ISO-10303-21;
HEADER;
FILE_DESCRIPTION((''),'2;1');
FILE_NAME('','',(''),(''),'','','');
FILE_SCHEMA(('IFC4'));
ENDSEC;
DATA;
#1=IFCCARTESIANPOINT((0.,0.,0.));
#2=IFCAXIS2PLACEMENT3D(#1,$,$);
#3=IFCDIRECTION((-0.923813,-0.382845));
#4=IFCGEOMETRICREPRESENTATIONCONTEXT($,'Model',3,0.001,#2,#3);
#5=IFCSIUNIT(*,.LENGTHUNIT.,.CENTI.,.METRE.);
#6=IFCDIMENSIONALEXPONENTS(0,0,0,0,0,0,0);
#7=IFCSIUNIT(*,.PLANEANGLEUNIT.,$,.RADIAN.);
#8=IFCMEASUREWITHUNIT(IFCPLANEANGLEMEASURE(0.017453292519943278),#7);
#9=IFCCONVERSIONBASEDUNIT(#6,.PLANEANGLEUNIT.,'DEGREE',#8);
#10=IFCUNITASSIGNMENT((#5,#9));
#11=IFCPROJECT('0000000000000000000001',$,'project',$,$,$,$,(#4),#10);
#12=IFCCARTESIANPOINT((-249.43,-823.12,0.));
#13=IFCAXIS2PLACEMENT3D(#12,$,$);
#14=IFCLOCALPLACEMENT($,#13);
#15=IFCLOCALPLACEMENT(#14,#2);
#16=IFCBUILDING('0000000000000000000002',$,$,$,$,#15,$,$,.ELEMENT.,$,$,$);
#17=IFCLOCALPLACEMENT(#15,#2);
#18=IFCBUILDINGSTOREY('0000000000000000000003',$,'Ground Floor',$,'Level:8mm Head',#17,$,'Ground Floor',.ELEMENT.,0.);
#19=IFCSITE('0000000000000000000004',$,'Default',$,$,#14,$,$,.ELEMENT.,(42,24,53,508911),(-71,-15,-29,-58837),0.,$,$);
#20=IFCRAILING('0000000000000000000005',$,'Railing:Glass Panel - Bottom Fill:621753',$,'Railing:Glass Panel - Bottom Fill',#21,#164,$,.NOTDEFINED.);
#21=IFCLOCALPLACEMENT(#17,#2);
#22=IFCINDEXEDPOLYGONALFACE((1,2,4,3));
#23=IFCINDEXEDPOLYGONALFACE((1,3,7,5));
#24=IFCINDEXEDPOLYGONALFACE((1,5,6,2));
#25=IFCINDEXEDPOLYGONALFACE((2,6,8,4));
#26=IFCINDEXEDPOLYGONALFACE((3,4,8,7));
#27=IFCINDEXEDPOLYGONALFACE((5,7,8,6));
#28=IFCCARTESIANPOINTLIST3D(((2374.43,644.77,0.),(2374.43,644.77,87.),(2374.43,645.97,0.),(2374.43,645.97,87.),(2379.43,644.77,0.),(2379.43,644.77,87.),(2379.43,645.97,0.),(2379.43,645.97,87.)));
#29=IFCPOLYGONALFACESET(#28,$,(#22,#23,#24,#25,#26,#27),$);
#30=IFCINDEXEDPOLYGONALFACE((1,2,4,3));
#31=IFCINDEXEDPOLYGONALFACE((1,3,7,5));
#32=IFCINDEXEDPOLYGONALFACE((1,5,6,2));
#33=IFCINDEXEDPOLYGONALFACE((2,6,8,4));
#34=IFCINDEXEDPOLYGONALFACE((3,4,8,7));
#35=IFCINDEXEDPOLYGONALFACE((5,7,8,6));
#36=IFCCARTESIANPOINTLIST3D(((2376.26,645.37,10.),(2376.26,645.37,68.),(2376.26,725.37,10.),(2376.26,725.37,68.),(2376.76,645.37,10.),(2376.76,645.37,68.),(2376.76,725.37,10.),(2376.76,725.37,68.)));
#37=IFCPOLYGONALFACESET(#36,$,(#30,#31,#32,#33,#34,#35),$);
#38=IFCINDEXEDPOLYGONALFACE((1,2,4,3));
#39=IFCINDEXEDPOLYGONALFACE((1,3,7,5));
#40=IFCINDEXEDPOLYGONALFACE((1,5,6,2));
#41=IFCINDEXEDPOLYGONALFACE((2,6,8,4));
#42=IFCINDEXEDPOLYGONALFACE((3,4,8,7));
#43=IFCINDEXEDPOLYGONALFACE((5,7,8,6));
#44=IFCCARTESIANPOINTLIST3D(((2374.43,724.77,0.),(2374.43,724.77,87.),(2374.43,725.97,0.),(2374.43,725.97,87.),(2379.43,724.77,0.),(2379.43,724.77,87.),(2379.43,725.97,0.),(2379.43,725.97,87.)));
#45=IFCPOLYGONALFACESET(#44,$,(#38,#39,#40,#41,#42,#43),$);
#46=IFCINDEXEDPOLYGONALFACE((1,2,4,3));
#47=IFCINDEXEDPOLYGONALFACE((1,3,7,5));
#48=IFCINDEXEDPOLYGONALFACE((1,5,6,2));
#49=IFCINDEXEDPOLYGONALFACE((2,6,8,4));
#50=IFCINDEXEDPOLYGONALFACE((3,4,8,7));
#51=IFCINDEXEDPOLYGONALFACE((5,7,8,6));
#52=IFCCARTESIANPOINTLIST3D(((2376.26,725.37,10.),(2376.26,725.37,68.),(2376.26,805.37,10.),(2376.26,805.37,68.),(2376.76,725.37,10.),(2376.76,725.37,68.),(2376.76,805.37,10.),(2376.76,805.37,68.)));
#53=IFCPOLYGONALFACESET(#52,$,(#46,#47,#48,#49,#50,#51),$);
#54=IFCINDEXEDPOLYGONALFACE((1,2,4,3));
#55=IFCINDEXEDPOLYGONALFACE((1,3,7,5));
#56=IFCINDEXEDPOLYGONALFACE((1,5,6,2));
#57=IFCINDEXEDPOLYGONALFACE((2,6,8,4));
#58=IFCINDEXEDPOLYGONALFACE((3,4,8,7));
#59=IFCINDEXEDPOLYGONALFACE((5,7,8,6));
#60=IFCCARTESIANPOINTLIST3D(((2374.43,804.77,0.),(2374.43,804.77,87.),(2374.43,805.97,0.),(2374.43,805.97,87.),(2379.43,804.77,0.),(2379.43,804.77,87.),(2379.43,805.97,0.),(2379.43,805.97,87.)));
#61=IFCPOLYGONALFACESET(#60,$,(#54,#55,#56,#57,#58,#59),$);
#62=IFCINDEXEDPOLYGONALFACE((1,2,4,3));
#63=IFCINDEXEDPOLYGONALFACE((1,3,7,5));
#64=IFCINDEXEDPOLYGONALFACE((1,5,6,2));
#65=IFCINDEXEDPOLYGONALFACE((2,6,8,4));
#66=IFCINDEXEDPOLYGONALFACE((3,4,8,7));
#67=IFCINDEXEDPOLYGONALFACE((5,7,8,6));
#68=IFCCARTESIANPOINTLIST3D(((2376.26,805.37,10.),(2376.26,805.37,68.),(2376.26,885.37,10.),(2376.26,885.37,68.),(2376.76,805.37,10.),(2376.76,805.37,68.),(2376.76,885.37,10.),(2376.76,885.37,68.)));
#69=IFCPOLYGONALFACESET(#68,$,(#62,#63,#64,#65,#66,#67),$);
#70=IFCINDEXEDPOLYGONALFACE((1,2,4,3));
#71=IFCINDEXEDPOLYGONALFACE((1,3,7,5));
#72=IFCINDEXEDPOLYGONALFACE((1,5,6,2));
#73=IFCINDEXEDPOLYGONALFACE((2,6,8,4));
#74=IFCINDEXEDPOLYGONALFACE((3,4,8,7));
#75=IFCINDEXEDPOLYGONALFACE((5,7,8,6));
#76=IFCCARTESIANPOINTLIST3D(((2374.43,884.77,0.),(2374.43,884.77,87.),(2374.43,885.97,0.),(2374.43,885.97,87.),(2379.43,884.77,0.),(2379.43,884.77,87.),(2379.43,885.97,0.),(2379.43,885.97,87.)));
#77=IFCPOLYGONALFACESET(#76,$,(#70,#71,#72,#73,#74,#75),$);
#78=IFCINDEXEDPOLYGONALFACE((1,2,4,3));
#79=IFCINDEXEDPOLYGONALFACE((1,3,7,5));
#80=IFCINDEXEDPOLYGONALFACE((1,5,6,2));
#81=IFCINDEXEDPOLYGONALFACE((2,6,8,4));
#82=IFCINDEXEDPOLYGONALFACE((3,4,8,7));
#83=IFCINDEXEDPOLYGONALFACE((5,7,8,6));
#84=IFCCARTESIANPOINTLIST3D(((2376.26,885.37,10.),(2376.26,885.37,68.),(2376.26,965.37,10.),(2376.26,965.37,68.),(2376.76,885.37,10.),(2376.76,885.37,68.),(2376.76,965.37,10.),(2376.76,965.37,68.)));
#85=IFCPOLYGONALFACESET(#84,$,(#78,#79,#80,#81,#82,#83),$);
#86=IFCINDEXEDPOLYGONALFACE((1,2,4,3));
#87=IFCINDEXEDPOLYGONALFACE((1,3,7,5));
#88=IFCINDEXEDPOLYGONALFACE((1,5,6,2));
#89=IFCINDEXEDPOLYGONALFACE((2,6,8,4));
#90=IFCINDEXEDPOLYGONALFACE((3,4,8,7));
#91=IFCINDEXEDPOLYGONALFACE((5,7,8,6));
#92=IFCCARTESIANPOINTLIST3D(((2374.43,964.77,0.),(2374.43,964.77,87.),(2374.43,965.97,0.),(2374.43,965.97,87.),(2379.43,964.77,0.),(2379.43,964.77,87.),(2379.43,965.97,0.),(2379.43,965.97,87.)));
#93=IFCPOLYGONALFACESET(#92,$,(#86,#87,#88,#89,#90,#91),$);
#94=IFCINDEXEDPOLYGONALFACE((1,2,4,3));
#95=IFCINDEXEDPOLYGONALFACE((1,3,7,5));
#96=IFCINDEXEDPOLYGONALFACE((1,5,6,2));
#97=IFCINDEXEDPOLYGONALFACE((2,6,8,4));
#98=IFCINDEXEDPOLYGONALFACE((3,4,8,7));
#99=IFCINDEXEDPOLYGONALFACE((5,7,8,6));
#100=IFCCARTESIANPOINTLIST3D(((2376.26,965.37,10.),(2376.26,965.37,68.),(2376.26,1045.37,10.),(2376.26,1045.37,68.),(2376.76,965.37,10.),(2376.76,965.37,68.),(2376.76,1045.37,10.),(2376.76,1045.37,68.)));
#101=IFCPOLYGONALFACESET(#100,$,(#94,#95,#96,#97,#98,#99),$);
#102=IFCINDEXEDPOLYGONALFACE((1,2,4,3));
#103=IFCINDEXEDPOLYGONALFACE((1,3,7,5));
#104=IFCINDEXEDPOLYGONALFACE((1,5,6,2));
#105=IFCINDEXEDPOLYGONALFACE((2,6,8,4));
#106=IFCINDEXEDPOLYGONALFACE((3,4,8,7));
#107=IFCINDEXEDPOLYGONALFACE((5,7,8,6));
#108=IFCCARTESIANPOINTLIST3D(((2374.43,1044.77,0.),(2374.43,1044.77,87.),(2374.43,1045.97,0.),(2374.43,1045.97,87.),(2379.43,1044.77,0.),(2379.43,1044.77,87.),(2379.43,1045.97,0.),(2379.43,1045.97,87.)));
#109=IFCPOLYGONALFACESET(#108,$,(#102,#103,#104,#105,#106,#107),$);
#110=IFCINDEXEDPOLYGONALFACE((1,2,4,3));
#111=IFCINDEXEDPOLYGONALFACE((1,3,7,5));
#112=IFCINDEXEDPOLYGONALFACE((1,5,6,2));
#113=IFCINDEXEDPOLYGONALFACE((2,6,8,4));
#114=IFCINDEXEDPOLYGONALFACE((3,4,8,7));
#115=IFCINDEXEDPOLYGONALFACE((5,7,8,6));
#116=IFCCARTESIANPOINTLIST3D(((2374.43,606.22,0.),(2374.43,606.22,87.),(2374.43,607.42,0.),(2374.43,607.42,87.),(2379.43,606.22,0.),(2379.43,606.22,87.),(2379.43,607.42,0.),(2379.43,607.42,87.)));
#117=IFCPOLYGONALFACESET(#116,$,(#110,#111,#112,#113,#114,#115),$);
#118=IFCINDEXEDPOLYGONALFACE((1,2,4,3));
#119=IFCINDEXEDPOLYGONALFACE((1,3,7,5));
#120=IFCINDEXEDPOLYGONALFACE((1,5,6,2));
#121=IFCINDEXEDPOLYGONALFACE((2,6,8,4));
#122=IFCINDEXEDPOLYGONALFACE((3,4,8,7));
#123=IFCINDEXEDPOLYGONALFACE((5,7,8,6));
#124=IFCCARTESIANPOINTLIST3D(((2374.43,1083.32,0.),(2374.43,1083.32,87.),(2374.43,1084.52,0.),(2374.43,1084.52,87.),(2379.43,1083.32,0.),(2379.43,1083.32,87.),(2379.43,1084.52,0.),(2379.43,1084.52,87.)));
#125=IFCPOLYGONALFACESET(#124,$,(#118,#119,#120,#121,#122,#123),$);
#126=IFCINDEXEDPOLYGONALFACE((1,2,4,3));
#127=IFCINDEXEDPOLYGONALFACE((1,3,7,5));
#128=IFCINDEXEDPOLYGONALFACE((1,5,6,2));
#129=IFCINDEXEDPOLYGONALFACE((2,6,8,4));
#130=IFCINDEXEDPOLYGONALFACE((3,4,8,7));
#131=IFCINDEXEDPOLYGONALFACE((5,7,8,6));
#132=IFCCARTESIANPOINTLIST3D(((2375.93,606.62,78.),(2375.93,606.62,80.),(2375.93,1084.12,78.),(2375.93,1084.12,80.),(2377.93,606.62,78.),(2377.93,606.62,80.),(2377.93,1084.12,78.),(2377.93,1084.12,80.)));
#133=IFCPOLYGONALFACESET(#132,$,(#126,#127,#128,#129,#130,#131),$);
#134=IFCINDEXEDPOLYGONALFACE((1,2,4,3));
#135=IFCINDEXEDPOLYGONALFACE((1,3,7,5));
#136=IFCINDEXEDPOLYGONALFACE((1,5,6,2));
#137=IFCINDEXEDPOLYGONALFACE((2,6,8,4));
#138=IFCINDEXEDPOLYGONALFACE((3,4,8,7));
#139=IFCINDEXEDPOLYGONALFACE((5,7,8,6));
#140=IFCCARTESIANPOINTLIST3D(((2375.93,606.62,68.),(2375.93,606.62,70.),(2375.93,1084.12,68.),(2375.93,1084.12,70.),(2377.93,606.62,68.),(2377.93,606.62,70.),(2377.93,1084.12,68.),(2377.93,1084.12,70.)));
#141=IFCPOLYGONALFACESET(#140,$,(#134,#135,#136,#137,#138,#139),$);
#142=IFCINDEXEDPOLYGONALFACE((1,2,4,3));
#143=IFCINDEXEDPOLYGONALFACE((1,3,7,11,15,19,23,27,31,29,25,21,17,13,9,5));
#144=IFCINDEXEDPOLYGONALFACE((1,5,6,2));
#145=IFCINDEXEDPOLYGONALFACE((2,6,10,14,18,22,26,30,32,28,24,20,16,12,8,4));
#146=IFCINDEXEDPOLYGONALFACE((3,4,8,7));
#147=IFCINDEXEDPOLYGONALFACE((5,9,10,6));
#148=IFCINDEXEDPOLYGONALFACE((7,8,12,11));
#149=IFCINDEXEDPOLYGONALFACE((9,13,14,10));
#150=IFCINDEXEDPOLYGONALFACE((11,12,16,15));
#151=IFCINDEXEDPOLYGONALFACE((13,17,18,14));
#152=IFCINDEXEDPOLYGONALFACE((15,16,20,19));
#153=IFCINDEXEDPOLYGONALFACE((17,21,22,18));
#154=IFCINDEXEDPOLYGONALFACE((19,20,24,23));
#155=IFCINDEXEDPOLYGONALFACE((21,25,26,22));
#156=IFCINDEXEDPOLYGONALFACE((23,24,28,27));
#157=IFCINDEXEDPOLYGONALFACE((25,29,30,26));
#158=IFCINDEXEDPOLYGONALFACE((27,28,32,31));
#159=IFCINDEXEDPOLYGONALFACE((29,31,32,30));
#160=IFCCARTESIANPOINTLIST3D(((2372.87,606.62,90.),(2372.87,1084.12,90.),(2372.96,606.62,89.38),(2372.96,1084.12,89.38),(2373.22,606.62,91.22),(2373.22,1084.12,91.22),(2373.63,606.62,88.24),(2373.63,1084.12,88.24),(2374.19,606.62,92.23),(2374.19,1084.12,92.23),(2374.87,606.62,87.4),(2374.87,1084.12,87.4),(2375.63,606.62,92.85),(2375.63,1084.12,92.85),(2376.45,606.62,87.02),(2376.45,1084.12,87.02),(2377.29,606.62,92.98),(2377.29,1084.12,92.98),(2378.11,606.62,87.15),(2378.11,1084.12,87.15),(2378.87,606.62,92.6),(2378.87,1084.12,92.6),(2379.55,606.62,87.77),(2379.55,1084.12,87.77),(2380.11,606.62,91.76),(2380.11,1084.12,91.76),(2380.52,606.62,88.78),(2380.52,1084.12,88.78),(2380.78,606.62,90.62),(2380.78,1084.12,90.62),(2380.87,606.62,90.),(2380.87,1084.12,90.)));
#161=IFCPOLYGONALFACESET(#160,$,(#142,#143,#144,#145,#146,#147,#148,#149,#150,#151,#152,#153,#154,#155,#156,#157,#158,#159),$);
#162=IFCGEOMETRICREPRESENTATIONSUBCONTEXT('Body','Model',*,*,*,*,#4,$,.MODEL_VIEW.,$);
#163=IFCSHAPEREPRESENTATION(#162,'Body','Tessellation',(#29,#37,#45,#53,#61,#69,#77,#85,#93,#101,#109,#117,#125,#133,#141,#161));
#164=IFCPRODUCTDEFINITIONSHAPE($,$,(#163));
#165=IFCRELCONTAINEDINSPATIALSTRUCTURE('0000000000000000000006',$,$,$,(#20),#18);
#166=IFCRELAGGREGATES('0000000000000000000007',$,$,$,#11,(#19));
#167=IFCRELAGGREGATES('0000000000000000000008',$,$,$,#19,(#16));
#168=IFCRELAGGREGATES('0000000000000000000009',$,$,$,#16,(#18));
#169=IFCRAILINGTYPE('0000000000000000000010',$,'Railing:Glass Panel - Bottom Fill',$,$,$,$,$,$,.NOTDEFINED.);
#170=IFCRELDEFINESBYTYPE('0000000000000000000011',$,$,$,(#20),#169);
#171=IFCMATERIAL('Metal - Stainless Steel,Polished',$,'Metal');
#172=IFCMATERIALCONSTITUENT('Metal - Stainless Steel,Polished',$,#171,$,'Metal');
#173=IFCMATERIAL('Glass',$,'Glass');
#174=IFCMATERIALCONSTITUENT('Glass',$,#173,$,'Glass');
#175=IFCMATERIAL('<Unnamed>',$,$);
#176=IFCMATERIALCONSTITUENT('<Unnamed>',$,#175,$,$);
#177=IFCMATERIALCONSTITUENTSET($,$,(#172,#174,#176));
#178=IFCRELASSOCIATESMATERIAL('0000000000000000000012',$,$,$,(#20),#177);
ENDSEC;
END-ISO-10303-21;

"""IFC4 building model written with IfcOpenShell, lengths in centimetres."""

from ifc_helpers import new_model, entity, si_unit, converted_unit, direction, frame, origin, place, context, subcontext, project, spatial, indexed_curve, outline, extrude, material, constituent, constituent_set, type_object, element, save


model = new_model("IFC4")

# Units and contexts
model_context = context("Model", 3, precision=0.001, world=origin(), true_north=direction((-0.923813, -0.382845)))
body_context = subcontext(model_context, "Body", "Model", "MODEL_VIEW")
ifc_project = project(units=[si_unit("LENGTHUNIT", "METRE", prefix="CENTI"), converted_unit("PLANEANGLEUNIT", "DEGREE", entity("IfcPlaneAngleMeasure", 0.017453292519943278), si_unit("PLANEANGLEUNIT", "RADIAN"), dimensions=[0, 0, 0, 0, 0, 0, 0])], contexts=[model_context])

# Site, building, storey
site_placement = place(None, frame((-249.43, -823.12, 0.0)))
site = spatial("IfcSite", under=ifc_project, at=site_placement, Name="Default", CompositionType="ELEMENT", RefLatitude=(42, 24, 53, 508911), RefLongitude=(-71, -15, -29, -58837), RefElevation=0.0)
building_placement = place(site_placement, origin())
building = spatial("IfcBuilding", under=site, at=building_placement, CompositionType="ELEMENT")
storey_placement = place(building_placement, origin())
storey = spatial("IfcBuildingStorey", under=building, at=storey_placement, Name="Ground Floor", ObjectType="Level:8mm Head", LongName="Ground Floor", CompositionType="ELEMENT", Elevation=0.0)

# Shared definitions
ifc_material_1 = material(Name="Glass", Category="Glass")

# Railing
ifc_material_2 = material(Name="Metal - Stainless Steel,Polished", Category="Metal")
ifc_material_3 = material(Name="<Unnamed>")
railing_type = type_object("IfcRailingType", Name="Railing:Glass Panel - Bottom Fill", PredefinedType="NOTDEFINED")
ifc_constituent_1 = constituent(ifc_material_2, Name="Metal - Stainless Steel,Polished", Category="Metal")
ifc_constituent_2 = constituent(ifc_material_1, Name="Glass", Category="Glass")
ifc_constituent_3 = constituent(ifc_material_3, Name="<Unnamed>")
ifc_constituent_set_1 = constituent_set(constituents=[ifc_constituent_1, ifc_constituent_2, ifc_constituent_3])
railing_1_placement = place(storey_placement, frame((2372.71, 606.22, 0.0)))
element("IfcRailing", 1, at=railing_1_placement, inside=storey, type_object=railing_type, material=ifc_constituent_set_1, Name="Railing:Glass Panel - Bottom Fill:621753", ObjectType="Railing:Glass Panel - Bottom Fill", PredefinedType="NOTDEFINED", context=body_context, shape_type="SweptSolid", body=[
    extrude(outline(indexed_curve([(-2.5, -0.6), (2.5, -0.6), (2.5, 0.6), (-2.5, 0.6), (-2.5, -0.6)], self_intersect=False)), frame((4.22, 39.15, 0.0), z_axis=(0.0, 0.0, 1.0), x_axis=(-1.0, 0.0, 0.0)), (0.0, 0.0, 1.0), 87.0),
    extrude(outline(indexed_curve([(-0.25, -40.0), (0.25, -40.0), (0.25, 40.0), (-0.25, 40.0), (-0.25, -40.0)], self_intersect=False)), frame((3.8, 79.15, 10.0), z_axis=(0.0, 0.0, 1.0), x_axis=(-1.0, 0.0, 0.0)), (0.0, 0.0, 1.0), 58.0),
    extrude(outline(indexed_curve([(-2.5, -0.6), (2.5, -0.6), (2.5, 0.6), (-2.5, 0.6), (-2.5, -0.6)], self_intersect=False)), frame((4.22, 119.15, 0.0), z_axis=(0.0, 0.0, 1.0), x_axis=(-1.0, 0.0, 0.0)), (0.0, 0.0, 1.0), 87.0),
    extrude(outline(indexed_curve([(-0.25, -40.0), (0.25, -40.0), (0.25, 40.0), (-0.25, 40.0), (-0.25, -40.0)], self_intersect=False)), frame((3.8, 159.15, 10.0), z_axis=(0.0, 0.0, 1.0), x_axis=(-1.0, 0.0, 0.0)), (0.0, 0.0, 1.0), 58.0),
    extrude(outline(indexed_curve([(-2.5, -0.6), (2.5, -0.6), (2.5, 0.6), (-2.5, 0.6), (-2.5, -0.6)], self_intersect=False)), frame((4.22, 199.15, 0.0), z_axis=(0.0, 0.0, 1.0), x_axis=(-1.0, 0.0, 0.0)), (0.0, 0.0, 1.0), 87.0),
    extrude(outline(indexed_curve([(-0.25, -40.0), (0.25, -40.0), (0.25, 40.0), (-0.25, 40.0), (-0.25, -40.0)], self_intersect=False)), frame((3.8, 239.15, 10.0), z_axis=(0.0, 0.0, 1.0), x_axis=(-1.0, 0.0, 0.0)), (0.0, 0.0, 1.0), 58.0),
    extrude(outline(indexed_curve([(-2.5, -0.6), (2.5, -0.6), (2.5, 0.6), (-2.5, 0.6), (-2.5, -0.6)], self_intersect=False)), frame((4.22, 279.15, 0.0), z_axis=(0.0, 0.0, 1.0), x_axis=(-1.0, 0.0, 0.0)), (0.0, 0.0, 1.0), 87.0),
    extrude(outline(indexed_curve([(-0.25, -40.0), (0.25, -40.0), (0.25, 40.0), (-0.25, 40.0), (-0.25, -40.0)], self_intersect=False)), frame((3.8, 319.15, 10.0), z_axis=(0.0, 0.0, 1.0), x_axis=(-1.0, 0.0, 0.0)), (0.0, 0.0, 1.0), 58.0),
    extrude(outline(indexed_curve([(-2.5, -0.6), (2.5, -0.6), (2.5, 0.6), (-2.5, 0.6), (-2.5, -0.6)], self_intersect=False)), frame((4.22, 359.15, 0.0), z_axis=(0.0, 0.0, 1.0), x_axis=(-1.0, 0.0, 0.0)), (0.0, 0.0, 1.0), 87.0),
    extrude(outline(indexed_curve([(-0.25, -40.0), (0.25, -40.0), (0.25, 40.0), (-0.25, 40.0), (-0.25, -40.0)], self_intersect=False)), frame((3.8, 399.15, 10.0), z_axis=(0.0, 0.0, 1.0), x_axis=(-1.0, 0.0, 0.0)), (0.0, 0.0, 1.0), 58.0),
    extrude(outline(indexed_curve([(-2.5, -0.6), (2.5, -0.6), (2.5, 0.6), (-2.5, 0.6), (-2.5, -0.6)], self_intersect=False)), frame((4.22, 439.15, 0.0), z_axis=(0.0, 0.0, 1.0), x_axis=(-1.0, 0.0, 0.0)), (0.0, 0.0, 1.0), 87.0),
    extrude(outline(indexed_curve([(-2.5, -0.6), (2.5, -0.6), (2.5, 0.6), (-2.5, 0.6), (-2.5, -0.6)], self_intersect=False)), frame((4.22, 0.6, 0.0), z_axis=(0.0, 0.0, 1.0), x_axis=(-1.0, 0.0, 0.0)), (0.0, 0.0, 1.0), 87.0),
    extrude(outline(indexed_curve([(-2.5, -0.6), (2.5, -0.6), (2.5, 0.6), (-2.5, 0.6), (-2.5, -0.6)], self_intersect=False)), frame((4.22, 477.7, 0.0), z_axis=(0.0, 0.0, 1.0), x_axis=(-1.0, 0.0, 0.0)), (0.0, 0.0, 1.0), 87.0),
    extrude(outline(indexed_curve([(-238.75, -1.0), (238.75, -1.0), (238.75, 1.0), (-238.75, 1.0), (-238.75, -1.0)], self_intersect=False)), frame((4.22, 239.15, 78.0), z_axis=(0.0, 0.0, 1.0), x_axis=(0.0, -1.0, 0.0)), (0.0, 0.0, 1.0), 2.0),
    extrude(outline(indexed_curve([(-238.75, -1.0), (238.75, -1.0), (238.75, 1.0), (-238.75, 1.0), (-238.75, -1.0)], self_intersect=False)), frame((4.22, 239.15, 68.0), z_axis=(0.0, 0.0, 1.0), x_axis=(0.0, -1.0, 0.0)), (0.0, 0.0, 1.0), 2.0),
    extrude(outline(indexed_curve([(-1.09, -3.85), (0.18, -3.85), (1.42, -3.18), (2.41, -1.97), (2.98, -0.41), (3.04, 1.22), (2.58, 2.63), (1.67, 3.59), (1.09, 3.85), (-0.18, 3.85), (-1.42, 3.18), (-2.41, 1.97), (-2.98, 0.41), (-3.04, -1.22), (-2.58, -2.63), (-1.67, -3.59), (-1.09, -3.85)], self_intersect=False)), frame((4.16, 0.4, 90.0), z_axis=(0.0, 1.0, 0.0), x_axis=(-0.27267, 0.0, -0.962108)), (0.0, 0.0, 1.0), 477.5),
])

save(model, "model.ifc")
